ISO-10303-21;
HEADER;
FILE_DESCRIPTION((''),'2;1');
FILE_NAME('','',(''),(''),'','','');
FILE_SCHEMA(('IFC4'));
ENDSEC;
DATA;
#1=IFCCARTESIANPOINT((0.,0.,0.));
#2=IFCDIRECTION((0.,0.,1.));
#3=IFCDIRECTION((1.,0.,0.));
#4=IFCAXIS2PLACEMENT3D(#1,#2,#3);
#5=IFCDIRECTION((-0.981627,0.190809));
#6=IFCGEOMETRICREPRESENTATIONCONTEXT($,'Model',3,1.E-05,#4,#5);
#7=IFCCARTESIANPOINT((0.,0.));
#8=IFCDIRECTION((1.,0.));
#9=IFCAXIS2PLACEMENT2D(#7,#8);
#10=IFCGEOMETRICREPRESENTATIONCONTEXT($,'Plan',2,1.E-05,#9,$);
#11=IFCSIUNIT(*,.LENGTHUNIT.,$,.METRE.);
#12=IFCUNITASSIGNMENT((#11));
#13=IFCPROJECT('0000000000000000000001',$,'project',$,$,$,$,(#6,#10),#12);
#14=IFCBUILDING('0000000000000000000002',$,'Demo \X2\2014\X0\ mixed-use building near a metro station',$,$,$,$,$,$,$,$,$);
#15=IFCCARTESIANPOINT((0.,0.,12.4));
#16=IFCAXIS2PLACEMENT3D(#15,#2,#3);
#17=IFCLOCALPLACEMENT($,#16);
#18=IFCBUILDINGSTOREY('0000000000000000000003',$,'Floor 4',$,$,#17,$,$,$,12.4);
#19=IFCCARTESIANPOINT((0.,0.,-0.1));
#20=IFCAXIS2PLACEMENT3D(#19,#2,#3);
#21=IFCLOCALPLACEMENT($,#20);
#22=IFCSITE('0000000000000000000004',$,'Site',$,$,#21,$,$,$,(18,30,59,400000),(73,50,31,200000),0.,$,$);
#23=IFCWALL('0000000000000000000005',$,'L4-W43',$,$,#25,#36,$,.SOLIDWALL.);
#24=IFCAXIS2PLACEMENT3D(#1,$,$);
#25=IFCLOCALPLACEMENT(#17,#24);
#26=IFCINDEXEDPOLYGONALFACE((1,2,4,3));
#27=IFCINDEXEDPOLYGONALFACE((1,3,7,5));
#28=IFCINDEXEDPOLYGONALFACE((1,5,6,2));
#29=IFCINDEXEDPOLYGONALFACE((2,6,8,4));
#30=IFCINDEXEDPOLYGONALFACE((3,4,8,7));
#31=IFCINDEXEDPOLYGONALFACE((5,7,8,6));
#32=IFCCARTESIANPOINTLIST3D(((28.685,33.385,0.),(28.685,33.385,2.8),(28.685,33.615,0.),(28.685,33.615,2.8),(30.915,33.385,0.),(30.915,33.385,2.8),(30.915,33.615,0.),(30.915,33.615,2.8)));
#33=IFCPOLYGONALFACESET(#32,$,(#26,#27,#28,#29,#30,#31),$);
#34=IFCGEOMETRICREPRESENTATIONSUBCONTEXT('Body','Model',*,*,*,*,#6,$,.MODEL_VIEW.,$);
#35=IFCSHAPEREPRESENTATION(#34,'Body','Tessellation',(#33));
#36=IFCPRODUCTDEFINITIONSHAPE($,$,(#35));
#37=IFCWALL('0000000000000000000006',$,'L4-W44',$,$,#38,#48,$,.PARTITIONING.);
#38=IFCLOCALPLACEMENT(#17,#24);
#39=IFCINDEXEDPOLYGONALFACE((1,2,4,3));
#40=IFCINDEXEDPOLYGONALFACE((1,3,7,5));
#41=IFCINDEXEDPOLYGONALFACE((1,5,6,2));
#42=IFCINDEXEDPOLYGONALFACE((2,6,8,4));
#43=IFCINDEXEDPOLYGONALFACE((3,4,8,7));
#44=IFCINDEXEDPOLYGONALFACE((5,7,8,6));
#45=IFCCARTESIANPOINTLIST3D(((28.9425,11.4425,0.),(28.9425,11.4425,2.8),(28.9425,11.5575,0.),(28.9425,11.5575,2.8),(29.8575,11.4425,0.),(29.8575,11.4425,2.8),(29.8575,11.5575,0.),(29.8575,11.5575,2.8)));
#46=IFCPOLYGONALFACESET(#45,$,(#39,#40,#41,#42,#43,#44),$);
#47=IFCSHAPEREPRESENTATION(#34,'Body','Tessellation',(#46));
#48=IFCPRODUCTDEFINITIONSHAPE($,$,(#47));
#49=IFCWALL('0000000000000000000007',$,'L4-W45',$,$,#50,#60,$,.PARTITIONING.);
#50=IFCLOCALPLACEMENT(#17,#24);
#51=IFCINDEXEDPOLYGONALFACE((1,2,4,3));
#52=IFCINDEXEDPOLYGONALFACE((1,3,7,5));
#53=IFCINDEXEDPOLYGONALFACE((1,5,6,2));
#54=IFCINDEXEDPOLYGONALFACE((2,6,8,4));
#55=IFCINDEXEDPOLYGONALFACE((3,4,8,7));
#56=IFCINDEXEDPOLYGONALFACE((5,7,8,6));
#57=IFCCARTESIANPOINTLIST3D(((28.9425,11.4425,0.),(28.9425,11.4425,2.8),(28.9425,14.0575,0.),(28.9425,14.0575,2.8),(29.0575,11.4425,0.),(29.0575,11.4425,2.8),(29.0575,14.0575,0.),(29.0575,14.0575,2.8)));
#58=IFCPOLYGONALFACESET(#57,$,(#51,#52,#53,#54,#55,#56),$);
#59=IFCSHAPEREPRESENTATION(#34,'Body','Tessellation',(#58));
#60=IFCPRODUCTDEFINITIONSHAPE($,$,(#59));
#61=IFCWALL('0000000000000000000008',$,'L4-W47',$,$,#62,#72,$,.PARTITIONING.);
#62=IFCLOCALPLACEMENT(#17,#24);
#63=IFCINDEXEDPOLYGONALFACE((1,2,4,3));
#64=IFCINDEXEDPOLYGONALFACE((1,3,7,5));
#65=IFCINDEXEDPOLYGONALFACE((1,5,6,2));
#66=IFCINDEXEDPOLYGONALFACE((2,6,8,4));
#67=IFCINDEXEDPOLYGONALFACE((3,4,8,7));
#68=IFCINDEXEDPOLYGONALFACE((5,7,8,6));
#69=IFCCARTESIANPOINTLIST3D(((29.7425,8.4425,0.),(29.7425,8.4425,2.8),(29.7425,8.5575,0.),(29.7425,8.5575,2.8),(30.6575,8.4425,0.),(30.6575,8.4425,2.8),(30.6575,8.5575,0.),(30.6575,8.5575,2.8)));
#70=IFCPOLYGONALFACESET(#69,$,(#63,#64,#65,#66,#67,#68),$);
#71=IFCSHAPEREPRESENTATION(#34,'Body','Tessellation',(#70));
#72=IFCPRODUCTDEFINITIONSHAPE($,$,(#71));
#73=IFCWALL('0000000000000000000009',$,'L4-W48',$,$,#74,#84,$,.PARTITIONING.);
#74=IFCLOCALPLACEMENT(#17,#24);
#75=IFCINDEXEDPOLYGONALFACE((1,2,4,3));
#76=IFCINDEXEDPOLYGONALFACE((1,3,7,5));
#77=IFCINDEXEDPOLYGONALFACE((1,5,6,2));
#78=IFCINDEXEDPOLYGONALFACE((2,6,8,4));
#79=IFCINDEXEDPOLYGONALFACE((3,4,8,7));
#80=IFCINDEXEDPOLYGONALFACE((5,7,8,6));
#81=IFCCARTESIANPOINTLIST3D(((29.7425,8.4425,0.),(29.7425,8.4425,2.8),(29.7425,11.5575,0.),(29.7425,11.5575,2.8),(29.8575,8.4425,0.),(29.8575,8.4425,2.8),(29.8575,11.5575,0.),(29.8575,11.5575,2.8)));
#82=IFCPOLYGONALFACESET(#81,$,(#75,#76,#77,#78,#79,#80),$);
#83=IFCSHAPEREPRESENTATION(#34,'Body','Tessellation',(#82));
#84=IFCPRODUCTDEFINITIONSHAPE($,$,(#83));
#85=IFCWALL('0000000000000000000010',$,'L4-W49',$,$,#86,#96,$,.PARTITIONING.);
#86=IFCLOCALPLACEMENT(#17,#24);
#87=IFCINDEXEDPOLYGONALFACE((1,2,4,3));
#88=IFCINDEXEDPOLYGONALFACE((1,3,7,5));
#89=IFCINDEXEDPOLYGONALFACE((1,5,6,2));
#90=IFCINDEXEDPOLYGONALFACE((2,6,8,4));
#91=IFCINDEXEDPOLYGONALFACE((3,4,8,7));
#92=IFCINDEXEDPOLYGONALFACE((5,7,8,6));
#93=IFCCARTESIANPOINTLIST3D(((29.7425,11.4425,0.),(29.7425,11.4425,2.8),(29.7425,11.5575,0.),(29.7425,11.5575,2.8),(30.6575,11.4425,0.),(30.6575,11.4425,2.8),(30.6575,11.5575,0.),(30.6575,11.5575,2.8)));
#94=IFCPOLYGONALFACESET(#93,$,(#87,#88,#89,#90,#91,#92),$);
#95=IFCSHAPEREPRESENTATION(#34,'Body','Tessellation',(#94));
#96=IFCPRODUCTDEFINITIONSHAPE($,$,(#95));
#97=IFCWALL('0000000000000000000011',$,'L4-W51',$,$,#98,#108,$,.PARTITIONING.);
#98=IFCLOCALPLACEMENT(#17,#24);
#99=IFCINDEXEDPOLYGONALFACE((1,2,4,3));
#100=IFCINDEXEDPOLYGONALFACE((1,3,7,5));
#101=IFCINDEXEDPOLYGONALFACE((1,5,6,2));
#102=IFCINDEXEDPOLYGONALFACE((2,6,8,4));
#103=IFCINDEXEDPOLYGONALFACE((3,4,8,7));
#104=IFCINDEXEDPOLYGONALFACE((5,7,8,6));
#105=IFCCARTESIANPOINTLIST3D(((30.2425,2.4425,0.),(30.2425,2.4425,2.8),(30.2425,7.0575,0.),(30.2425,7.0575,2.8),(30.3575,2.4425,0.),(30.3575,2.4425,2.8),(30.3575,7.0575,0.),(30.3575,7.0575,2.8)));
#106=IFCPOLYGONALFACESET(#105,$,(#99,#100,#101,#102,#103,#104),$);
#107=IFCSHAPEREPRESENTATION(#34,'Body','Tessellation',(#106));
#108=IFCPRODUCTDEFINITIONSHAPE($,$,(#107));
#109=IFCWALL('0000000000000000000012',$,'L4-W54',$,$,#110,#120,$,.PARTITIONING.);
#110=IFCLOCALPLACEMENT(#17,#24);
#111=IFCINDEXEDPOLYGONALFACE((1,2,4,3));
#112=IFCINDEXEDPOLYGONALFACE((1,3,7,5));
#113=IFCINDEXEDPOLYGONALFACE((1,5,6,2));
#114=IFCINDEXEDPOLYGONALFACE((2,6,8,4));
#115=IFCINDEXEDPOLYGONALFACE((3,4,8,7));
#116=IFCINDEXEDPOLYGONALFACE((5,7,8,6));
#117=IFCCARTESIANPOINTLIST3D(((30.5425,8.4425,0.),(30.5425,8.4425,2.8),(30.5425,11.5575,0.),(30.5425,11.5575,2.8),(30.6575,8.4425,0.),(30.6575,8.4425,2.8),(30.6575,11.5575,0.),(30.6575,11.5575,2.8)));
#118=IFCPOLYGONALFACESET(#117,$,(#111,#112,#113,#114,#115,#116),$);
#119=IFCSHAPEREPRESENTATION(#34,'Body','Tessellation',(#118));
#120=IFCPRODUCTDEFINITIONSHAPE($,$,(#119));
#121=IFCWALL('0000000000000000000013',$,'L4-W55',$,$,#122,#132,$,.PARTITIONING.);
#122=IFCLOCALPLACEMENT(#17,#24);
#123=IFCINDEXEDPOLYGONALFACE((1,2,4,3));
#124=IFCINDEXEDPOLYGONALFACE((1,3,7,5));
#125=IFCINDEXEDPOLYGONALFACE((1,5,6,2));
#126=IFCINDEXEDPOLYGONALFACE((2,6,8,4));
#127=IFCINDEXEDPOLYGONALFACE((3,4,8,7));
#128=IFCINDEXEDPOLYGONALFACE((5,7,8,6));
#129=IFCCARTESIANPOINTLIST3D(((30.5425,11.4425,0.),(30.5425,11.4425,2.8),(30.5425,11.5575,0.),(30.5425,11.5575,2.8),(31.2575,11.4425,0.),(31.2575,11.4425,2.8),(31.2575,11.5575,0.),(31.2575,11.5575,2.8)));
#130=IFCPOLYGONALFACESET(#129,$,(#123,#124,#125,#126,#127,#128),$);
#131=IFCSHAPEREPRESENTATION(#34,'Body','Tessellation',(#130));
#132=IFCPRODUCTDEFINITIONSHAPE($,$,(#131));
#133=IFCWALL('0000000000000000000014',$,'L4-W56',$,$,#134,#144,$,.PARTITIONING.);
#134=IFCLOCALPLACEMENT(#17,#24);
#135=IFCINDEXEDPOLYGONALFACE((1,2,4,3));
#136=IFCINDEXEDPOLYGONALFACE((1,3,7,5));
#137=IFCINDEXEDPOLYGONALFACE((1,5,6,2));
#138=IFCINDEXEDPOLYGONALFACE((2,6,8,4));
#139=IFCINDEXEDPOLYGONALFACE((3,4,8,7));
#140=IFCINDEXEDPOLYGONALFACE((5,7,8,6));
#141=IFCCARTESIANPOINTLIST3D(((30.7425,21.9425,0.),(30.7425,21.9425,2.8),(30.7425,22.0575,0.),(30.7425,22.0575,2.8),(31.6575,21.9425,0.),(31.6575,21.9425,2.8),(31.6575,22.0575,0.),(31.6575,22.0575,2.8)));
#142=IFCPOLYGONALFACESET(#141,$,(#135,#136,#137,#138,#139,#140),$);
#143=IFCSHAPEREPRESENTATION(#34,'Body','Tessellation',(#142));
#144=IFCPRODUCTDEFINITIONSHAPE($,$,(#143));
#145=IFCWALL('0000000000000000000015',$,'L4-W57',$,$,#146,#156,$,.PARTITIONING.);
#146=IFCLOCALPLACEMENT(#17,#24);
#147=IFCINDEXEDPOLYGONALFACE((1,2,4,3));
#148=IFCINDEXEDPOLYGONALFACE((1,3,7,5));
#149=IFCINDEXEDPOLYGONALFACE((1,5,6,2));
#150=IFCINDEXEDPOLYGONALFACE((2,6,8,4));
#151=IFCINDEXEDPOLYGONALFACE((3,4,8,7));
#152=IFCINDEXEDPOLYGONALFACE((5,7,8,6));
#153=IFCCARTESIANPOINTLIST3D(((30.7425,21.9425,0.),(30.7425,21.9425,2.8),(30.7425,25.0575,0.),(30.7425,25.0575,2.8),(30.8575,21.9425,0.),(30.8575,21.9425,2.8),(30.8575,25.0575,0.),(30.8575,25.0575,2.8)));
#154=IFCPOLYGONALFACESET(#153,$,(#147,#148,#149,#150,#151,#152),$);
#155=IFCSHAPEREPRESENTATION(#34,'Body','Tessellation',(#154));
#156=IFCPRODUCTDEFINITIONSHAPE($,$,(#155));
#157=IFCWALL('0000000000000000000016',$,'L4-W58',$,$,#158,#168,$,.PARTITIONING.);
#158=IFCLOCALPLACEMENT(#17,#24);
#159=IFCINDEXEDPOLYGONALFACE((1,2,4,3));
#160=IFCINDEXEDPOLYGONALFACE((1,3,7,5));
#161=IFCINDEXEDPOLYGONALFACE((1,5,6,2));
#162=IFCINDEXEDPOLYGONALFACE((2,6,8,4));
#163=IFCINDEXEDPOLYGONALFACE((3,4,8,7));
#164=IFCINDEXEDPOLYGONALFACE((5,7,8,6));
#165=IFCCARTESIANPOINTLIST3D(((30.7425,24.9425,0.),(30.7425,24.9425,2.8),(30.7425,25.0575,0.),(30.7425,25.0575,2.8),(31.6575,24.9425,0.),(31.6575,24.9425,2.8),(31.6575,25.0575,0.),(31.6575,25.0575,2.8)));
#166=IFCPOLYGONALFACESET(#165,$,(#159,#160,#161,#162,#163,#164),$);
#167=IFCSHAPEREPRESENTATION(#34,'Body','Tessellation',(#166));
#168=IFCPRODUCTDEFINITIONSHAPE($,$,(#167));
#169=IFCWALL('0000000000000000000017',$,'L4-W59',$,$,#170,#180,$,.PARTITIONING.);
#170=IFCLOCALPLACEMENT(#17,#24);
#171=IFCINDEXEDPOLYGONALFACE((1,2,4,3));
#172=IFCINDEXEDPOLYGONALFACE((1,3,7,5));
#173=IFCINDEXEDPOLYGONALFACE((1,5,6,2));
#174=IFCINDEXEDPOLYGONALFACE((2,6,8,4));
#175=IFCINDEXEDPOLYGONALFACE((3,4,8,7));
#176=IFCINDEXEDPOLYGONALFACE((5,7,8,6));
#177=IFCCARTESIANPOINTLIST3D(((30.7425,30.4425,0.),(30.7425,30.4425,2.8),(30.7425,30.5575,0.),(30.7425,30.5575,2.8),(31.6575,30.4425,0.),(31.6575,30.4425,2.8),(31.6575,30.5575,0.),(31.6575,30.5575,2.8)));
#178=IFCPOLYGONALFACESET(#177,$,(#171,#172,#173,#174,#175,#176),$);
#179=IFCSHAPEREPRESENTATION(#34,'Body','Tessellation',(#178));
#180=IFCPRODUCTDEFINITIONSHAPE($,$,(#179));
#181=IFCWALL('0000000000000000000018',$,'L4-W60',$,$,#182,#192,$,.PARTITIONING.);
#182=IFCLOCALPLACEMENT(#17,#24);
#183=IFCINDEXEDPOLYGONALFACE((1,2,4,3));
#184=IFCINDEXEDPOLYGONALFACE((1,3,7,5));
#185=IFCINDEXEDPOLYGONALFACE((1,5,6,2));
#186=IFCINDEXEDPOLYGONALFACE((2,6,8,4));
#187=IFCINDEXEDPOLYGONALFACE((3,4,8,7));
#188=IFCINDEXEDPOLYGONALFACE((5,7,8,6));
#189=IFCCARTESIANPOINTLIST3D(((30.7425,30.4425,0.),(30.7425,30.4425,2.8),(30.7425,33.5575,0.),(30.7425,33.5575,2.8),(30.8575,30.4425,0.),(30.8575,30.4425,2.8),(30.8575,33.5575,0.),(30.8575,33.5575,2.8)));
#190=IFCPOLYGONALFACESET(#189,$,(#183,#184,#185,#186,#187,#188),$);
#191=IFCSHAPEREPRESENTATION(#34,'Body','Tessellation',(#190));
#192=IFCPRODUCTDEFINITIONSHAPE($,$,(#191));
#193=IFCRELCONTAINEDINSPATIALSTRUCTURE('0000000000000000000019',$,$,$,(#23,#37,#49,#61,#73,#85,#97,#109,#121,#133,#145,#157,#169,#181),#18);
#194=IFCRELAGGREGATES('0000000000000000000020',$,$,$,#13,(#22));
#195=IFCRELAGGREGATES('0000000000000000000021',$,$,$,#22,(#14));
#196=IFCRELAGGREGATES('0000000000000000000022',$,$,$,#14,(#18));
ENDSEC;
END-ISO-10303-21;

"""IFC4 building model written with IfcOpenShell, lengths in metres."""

from ifc_helpers import new_model, si_unit, direction, frame, origin_with_axes, origin_2d_with_axis, place, context, subcontext, project, spatial, line, indexed_curve, outline, extrude, element, save


model = new_model("IFC4")

# Units and contexts
model_context = context("Model", 3, precision=1e-05, world=origin_with_axes(), true_north=direction((-0.981627, 0.190809)))
plan_context = context("Plan", 2, precision=1e-05, world=origin_2d_with_axis())
body_context = subcontext(model_context, "Body", "Model", "MODEL_VIEW")
ifc_project = project(units=[si_unit("LENGTHUNIT", "METRE")], contexts=[model_context, plan_context])

# Site, building, storey
site_placement = place(None, frame((0.0, 0.0, -0.1), z_axis=(0.0, 0.0, 1.0), x_axis=(1.0, 0.0, 0.0)))
site = spatial("IfcSite", under=ifc_project, at=site_placement, Name="Site", RefLatitude=(18, 30, 59, 400000), RefLongitude=(73, 50, 31, 200000), RefElevation=0.0)
building = spatial("IfcBuilding", under=site, Name="Demo — mixed-use building near a metro station")
storey_placement = place(None, frame((0.0, 0.0, 12.4), z_axis=(0.0, 0.0, 1.0), x_axis=(1.0, 0.0, 0.0)))
storey = spatial("IfcBuildingStorey", under=building, at=storey_placement, Name="Floor 4", Elevation=12.4)

# Walls
wall_1_placement = place(storey_placement, frame((0.0, 0.0, -12.4), z_axis=(0.0, 0.0, 1.0), x_axis=(1.0, 0.0, 0.0)))
element("IfcWall", 1, at=wall_1_placement, inside=storey, Name="L4-W43", PredefinedType="SOLIDWALL", context=body_context, shape_type="SweptSolid", body=[
    extrude(outline(indexed_curve([(30.915, 33.385), (28.685, 33.385), (28.685, 33.615), (30.915, 33.615)], segments=[line(1, 2, 3, 4, 1)])), frame((0.0, 0.0, 12.4), z_axis=(0.0, 0.0, 1.0), x_axis=(1.0, 0.0, 0.0)), (0.0, 0.0, 1.0), 2.8),
])
wall_2_placement = place(storey_placement, frame((0.0, 0.0, -12.4), z_axis=(0.0, 0.0, 1.0), x_axis=(1.0, 0.0, 0.0)))
element("IfcWall", 2, at=wall_2_placement, inside=storey, Name="L4-W44", PredefinedType="PARTITIONING", context=body_context, shape_type="SweptSolid", body=[
    extrude(outline(indexed_curve([(28.9425, 11.5575), (29.8575, 11.5575), (29.8575, 11.4425), (28.9425, 11.4425)], segments=[line(1, 2, 3, 4, 1)])), frame((0.0, 0.0, 12.4), z_axis=(0.0, 0.0, 1.0), x_axis=(1.0, 0.0, 0.0)), (0.0, 0.0, 1.0), 2.8),
])
wall_3_placement = place(storey_placement, frame((0.0, 0.0, -12.4), z_axis=(0.0, 0.0, 1.0), x_axis=(1.0, 0.0, 0.0)))
element("IfcWall", 3, at=wall_3_placement, inside=storey, Name="L4-W45", PredefinedType="PARTITIONING", context=body_context, shape_type="SweptSolid", body=[
    extrude(outline(indexed_curve([(28.9425, 11.4425), (28.9425, 14.0575), (29.0575, 14.0575), (29.0575, 11.4425)], segments=[line(1, 2, 3, 4, 1)])), frame((0.0, 0.0, 12.4), z_axis=(0.0, 0.0, 1.0), x_axis=(1.0, 0.0, 0.0)), (0.0, 0.0, 1.0), 2.8),
])

# Walls
wall_4_placement = place(storey_placement, frame((0.0, 0.0, -12.4), z_axis=(0.0, 0.0, 1.0), x_axis=(1.0, 0.0, 0.0)))
element("IfcWall", 4, at=wall_4_placement, inside=storey, Name="L4-W47", PredefinedType="PARTITIONING", context=body_context, shape_type="SweptSolid", body=[
    extrude(outline(indexed_curve([(30.6575, 8.4425), (29.7425, 8.4425), (29.7425, 8.5575), (30.6575, 8.5575)], segments=[line(1, 2, 3, 4, 1)])), frame((0.0, 0.0, 12.4), z_axis=(0.0, 0.0, 1.0), x_axis=(1.0, 0.0, 0.0)), (0.0, 0.0, 1.0), 2.8),
])
wall_5_placement = place(storey_placement, frame((0.0, 0.0, -12.4), z_axis=(0.0, 0.0, 1.0), x_axis=(1.0, 0.0, 0.0)))
element("IfcWall", 5, at=wall_5_placement, inside=storey, Name="L4-W48", PredefinedType="PARTITIONING", context=body_context, shape_type="SweptSolid", body=[
    extrude(outline(indexed_curve([(29.7425, 8.4425), (29.7425, 11.5575), (29.8575, 11.5575), (29.8575, 8.4425)], segments=[line(1, 2, 3, 4, 1)])), frame((0.0, 0.0, 12.4), z_axis=(0.0, 0.0, 1.0), x_axis=(1.0, 0.0, 0.0)), (0.0, 0.0, 1.0), 2.8),
])
wall_6_placement = place(storey_placement, frame((0.0, 0.0, -12.4), z_axis=(0.0, 0.0, 1.0), x_axis=(1.0, 0.0, 0.0)))
element("IfcWall", 6, at=wall_6_placement, inside=storey, Name="L4-W49", PredefinedType="PARTITIONING", context=body_context, shape_type="SweptSolid", body=[
    extrude(outline(indexed_curve([(29.7425, 11.5575), (30.6575, 11.5575), (30.6575, 11.4425), (29.7425, 11.4425)], segments=[line(1, 2, 3, 4, 1)])), frame((0.0, 0.0, 12.4), z_axis=(0.0, 0.0, 1.0), x_axis=(1.0, 0.0, 0.0)), (0.0, 0.0, 1.0), 2.8),
])

# Wall
wall_7_placement = place(storey_placement, frame((0.0, 0.0, -12.4), z_axis=(0.0, 0.0, 1.0), x_axis=(1.0, 0.0, 0.0)))
element("IfcWall", 7, at=wall_7_placement, inside=storey, Name="L4-W51", PredefinedType="PARTITIONING", context=body_context, shape_type="SweptSolid", body=[
    extrude(outline(indexed_curve([(30.2425, 2.4425), (30.2425, 7.0575), (30.3575, 7.0575), (30.3575, 2.4425)], segments=[line(1, 2, 3, 4, 1)])), frame((0.0, 0.0, 12.4), z_axis=(0.0, 0.0, 1.0), x_axis=(1.0, 0.0, 0.0)), (0.0, 0.0, 1.0), 2.8),
])

# Walls
wall_8_placement = place(storey_placement, frame((0.0, 0.0, -12.4), z_axis=(0.0, 0.0, 1.0), x_axis=(1.0, 0.0, 0.0)))
element("IfcWall", 8, at=wall_8_placement, inside=storey, Name="L4-W54", PredefinedType="PARTITIONING", context=body_context, shape_type="SweptSolid", body=[
    extrude(outline(indexed_curve([(30.5425, 8.4425), (30.5425, 11.5575), (30.6575, 11.5575), (30.6575, 8.4425)], segments=[line(1, 2, 3, 4, 1)])), frame((0.0, 0.0, 12.4), z_axis=(0.0, 0.0, 1.0), x_axis=(1.0, 0.0, 0.0)), (0.0, 0.0, 1.0), 2.8),
])
wall_9_placement = place(storey_placement, frame((0.0, 0.0, -12.4), z_axis=(0.0, 0.0, 1.0), x_axis=(1.0, 0.0, 0.0)))
element("IfcWall", 9, at=wall_9_placement, inside=storey, Name="L4-W55", PredefinedType="PARTITIONING", context=body_context, shape_type="SweptSolid", body=[
    extrude(outline(indexed_curve([(30.5425, 11.5575), (31.2575, 11.5575), (31.2575, 11.4425), (30.5425, 11.4425)], segments=[line(1, 2, 3, 4, 1)])), frame((0.0, 0.0, 12.4), z_axis=(0.0, 0.0, 1.0), x_axis=(1.0, 0.0, 0.0)), (0.0, 0.0, 1.0), 2.8),
])
wall_10_placement = place(storey_placement, frame((0.0, 0.0, -12.4), z_axis=(0.0, 0.0, 1.0), x_axis=(1.0, 0.0, 0.0)))
element("IfcWall", 10, at=wall_10_placement, inside=storey, Name="L4-W56", PredefinedType="PARTITIONING", context=body_context, shape_type="SweptSolid", body=[
    extrude(outline(indexed_curve([(31.6575, 21.9425), (30.7425, 21.9425), (30.7425, 22.0575), (31.6575, 22.0575)], segments=[line(1, 2, 3, 4, 1)])), frame((0.0, 0.0, 12.4), z_axis=(0.0, 0.0, 1.0), x_axis=(1.0, 0.0, 0.0)), (0.0, 0.0, 1.0), 2.8),
])
wall_11_placement = place(storey_placement, frame((0.0, 0.0, -12.4), z_axis=(0.0, 0.0, 1.0), x_axis=(1.0, 0.0, 0.0)))
element("IfcWall", 11, at=wall_11_placement, inside=storey, Name="L4-W57", PredefinedType="PARTITIONING", context=body_context, shape_type="SweptSolid", body=[
    extrude(outline(indexed_curve([(30.7425, 21.9425), (30.7425, 25.0575), (30.8575, 25.0575), (30.8575, 21.9425)], segments=[line(1, 2, 3, 4, 1)])), frame((0.0, 0.0, 12.4), z_axis=(0.0, 0.0, 1.0), x_axis=(1.0, 0.0, 0.0)), (0.0, 0.0, 1.0), 2.8),
])
wall_12_placement = place(storey_placement, frame((0.0, 0.0, -12.4), z_axis=(0.0, 0.0, 1.0), x_axis=(1.0, 0.0, 0.0)))
element("IfcWall", 12, at=wall_12_placement, inside=storey, Name="L4-W58", PredefinedType="PARTITIONING", context=body_context, shape_type="SweptSolid", body=[
    extrude(outline(indexed_curve([(31.6575, 24.9425), (30.7425, 24.9425), (30.7425, 25.0575), (31.6575, 25.0575)], segments=[line(1, 2, 3, 4, 1)])), frame((0.0, 0.0, 12.4), z_axis=(0.0, 0.0, 1.0), x_axis=(1.0, 0.0, 0.0)), (0.0, 0.0, 1.0), 2.8),
])
wall_13_placement = place(storey_placement, frame((0.0, 0.0, -12.4), z_axis=(0.0, 0.0, 1.0), x_axis=(1.0, 0.0, 0.0)))
element("IfcWall", 13, at=wall_13_placement, inside=storey, Name="L4-W59", PredefinedType="PARTITIONING", context=body_context, shape_type="SweptSolid", body=[
    extrude(outline(indexed_curve([(31.6575, 30.4425), (30.7425, 30.4425), (30.7425, 30.5575), (31.6575, 30.5575)], segments=[line(1, 2, 3, 4, 1)])), frame((0.0, 0.0, 12.4), z_axis=(0.0, 0.0, 1.0), x_axis=(1.0, 0.0, 0.0)), (0.0, 0.0, 1.0), 2.8),
])
wall_14_placement = place(storey_placement, frame((0.0, 0.0, -12.4), z_axis=(0.0, 0.0, 1.0), x_axis=(1.0, 0.0, 0.0)))
element("IfcWall", 14, at=wall_14_placement, inside=storey, Name="L4-W60", PredefinedType="PARTITIONING", context=body_context, shape_type="SweptSolid", body=[
    extrude(outline(indexed_curve([(30.7425, 30.4425), (30.7425, 33.5575), (30.8575, 33.5575), (30.8575, 30.4425)], segments=[line(1, 2, 3, 4, 1)])), frame((0.0, 0.0, 12.4), z_axis=(0.0, 0.0, 1.0), x_axis=(1.0, 0.0, 0.0)), (0.0, 0.0, 1.0), 2.8),
])

save(model, "model.ifc")
